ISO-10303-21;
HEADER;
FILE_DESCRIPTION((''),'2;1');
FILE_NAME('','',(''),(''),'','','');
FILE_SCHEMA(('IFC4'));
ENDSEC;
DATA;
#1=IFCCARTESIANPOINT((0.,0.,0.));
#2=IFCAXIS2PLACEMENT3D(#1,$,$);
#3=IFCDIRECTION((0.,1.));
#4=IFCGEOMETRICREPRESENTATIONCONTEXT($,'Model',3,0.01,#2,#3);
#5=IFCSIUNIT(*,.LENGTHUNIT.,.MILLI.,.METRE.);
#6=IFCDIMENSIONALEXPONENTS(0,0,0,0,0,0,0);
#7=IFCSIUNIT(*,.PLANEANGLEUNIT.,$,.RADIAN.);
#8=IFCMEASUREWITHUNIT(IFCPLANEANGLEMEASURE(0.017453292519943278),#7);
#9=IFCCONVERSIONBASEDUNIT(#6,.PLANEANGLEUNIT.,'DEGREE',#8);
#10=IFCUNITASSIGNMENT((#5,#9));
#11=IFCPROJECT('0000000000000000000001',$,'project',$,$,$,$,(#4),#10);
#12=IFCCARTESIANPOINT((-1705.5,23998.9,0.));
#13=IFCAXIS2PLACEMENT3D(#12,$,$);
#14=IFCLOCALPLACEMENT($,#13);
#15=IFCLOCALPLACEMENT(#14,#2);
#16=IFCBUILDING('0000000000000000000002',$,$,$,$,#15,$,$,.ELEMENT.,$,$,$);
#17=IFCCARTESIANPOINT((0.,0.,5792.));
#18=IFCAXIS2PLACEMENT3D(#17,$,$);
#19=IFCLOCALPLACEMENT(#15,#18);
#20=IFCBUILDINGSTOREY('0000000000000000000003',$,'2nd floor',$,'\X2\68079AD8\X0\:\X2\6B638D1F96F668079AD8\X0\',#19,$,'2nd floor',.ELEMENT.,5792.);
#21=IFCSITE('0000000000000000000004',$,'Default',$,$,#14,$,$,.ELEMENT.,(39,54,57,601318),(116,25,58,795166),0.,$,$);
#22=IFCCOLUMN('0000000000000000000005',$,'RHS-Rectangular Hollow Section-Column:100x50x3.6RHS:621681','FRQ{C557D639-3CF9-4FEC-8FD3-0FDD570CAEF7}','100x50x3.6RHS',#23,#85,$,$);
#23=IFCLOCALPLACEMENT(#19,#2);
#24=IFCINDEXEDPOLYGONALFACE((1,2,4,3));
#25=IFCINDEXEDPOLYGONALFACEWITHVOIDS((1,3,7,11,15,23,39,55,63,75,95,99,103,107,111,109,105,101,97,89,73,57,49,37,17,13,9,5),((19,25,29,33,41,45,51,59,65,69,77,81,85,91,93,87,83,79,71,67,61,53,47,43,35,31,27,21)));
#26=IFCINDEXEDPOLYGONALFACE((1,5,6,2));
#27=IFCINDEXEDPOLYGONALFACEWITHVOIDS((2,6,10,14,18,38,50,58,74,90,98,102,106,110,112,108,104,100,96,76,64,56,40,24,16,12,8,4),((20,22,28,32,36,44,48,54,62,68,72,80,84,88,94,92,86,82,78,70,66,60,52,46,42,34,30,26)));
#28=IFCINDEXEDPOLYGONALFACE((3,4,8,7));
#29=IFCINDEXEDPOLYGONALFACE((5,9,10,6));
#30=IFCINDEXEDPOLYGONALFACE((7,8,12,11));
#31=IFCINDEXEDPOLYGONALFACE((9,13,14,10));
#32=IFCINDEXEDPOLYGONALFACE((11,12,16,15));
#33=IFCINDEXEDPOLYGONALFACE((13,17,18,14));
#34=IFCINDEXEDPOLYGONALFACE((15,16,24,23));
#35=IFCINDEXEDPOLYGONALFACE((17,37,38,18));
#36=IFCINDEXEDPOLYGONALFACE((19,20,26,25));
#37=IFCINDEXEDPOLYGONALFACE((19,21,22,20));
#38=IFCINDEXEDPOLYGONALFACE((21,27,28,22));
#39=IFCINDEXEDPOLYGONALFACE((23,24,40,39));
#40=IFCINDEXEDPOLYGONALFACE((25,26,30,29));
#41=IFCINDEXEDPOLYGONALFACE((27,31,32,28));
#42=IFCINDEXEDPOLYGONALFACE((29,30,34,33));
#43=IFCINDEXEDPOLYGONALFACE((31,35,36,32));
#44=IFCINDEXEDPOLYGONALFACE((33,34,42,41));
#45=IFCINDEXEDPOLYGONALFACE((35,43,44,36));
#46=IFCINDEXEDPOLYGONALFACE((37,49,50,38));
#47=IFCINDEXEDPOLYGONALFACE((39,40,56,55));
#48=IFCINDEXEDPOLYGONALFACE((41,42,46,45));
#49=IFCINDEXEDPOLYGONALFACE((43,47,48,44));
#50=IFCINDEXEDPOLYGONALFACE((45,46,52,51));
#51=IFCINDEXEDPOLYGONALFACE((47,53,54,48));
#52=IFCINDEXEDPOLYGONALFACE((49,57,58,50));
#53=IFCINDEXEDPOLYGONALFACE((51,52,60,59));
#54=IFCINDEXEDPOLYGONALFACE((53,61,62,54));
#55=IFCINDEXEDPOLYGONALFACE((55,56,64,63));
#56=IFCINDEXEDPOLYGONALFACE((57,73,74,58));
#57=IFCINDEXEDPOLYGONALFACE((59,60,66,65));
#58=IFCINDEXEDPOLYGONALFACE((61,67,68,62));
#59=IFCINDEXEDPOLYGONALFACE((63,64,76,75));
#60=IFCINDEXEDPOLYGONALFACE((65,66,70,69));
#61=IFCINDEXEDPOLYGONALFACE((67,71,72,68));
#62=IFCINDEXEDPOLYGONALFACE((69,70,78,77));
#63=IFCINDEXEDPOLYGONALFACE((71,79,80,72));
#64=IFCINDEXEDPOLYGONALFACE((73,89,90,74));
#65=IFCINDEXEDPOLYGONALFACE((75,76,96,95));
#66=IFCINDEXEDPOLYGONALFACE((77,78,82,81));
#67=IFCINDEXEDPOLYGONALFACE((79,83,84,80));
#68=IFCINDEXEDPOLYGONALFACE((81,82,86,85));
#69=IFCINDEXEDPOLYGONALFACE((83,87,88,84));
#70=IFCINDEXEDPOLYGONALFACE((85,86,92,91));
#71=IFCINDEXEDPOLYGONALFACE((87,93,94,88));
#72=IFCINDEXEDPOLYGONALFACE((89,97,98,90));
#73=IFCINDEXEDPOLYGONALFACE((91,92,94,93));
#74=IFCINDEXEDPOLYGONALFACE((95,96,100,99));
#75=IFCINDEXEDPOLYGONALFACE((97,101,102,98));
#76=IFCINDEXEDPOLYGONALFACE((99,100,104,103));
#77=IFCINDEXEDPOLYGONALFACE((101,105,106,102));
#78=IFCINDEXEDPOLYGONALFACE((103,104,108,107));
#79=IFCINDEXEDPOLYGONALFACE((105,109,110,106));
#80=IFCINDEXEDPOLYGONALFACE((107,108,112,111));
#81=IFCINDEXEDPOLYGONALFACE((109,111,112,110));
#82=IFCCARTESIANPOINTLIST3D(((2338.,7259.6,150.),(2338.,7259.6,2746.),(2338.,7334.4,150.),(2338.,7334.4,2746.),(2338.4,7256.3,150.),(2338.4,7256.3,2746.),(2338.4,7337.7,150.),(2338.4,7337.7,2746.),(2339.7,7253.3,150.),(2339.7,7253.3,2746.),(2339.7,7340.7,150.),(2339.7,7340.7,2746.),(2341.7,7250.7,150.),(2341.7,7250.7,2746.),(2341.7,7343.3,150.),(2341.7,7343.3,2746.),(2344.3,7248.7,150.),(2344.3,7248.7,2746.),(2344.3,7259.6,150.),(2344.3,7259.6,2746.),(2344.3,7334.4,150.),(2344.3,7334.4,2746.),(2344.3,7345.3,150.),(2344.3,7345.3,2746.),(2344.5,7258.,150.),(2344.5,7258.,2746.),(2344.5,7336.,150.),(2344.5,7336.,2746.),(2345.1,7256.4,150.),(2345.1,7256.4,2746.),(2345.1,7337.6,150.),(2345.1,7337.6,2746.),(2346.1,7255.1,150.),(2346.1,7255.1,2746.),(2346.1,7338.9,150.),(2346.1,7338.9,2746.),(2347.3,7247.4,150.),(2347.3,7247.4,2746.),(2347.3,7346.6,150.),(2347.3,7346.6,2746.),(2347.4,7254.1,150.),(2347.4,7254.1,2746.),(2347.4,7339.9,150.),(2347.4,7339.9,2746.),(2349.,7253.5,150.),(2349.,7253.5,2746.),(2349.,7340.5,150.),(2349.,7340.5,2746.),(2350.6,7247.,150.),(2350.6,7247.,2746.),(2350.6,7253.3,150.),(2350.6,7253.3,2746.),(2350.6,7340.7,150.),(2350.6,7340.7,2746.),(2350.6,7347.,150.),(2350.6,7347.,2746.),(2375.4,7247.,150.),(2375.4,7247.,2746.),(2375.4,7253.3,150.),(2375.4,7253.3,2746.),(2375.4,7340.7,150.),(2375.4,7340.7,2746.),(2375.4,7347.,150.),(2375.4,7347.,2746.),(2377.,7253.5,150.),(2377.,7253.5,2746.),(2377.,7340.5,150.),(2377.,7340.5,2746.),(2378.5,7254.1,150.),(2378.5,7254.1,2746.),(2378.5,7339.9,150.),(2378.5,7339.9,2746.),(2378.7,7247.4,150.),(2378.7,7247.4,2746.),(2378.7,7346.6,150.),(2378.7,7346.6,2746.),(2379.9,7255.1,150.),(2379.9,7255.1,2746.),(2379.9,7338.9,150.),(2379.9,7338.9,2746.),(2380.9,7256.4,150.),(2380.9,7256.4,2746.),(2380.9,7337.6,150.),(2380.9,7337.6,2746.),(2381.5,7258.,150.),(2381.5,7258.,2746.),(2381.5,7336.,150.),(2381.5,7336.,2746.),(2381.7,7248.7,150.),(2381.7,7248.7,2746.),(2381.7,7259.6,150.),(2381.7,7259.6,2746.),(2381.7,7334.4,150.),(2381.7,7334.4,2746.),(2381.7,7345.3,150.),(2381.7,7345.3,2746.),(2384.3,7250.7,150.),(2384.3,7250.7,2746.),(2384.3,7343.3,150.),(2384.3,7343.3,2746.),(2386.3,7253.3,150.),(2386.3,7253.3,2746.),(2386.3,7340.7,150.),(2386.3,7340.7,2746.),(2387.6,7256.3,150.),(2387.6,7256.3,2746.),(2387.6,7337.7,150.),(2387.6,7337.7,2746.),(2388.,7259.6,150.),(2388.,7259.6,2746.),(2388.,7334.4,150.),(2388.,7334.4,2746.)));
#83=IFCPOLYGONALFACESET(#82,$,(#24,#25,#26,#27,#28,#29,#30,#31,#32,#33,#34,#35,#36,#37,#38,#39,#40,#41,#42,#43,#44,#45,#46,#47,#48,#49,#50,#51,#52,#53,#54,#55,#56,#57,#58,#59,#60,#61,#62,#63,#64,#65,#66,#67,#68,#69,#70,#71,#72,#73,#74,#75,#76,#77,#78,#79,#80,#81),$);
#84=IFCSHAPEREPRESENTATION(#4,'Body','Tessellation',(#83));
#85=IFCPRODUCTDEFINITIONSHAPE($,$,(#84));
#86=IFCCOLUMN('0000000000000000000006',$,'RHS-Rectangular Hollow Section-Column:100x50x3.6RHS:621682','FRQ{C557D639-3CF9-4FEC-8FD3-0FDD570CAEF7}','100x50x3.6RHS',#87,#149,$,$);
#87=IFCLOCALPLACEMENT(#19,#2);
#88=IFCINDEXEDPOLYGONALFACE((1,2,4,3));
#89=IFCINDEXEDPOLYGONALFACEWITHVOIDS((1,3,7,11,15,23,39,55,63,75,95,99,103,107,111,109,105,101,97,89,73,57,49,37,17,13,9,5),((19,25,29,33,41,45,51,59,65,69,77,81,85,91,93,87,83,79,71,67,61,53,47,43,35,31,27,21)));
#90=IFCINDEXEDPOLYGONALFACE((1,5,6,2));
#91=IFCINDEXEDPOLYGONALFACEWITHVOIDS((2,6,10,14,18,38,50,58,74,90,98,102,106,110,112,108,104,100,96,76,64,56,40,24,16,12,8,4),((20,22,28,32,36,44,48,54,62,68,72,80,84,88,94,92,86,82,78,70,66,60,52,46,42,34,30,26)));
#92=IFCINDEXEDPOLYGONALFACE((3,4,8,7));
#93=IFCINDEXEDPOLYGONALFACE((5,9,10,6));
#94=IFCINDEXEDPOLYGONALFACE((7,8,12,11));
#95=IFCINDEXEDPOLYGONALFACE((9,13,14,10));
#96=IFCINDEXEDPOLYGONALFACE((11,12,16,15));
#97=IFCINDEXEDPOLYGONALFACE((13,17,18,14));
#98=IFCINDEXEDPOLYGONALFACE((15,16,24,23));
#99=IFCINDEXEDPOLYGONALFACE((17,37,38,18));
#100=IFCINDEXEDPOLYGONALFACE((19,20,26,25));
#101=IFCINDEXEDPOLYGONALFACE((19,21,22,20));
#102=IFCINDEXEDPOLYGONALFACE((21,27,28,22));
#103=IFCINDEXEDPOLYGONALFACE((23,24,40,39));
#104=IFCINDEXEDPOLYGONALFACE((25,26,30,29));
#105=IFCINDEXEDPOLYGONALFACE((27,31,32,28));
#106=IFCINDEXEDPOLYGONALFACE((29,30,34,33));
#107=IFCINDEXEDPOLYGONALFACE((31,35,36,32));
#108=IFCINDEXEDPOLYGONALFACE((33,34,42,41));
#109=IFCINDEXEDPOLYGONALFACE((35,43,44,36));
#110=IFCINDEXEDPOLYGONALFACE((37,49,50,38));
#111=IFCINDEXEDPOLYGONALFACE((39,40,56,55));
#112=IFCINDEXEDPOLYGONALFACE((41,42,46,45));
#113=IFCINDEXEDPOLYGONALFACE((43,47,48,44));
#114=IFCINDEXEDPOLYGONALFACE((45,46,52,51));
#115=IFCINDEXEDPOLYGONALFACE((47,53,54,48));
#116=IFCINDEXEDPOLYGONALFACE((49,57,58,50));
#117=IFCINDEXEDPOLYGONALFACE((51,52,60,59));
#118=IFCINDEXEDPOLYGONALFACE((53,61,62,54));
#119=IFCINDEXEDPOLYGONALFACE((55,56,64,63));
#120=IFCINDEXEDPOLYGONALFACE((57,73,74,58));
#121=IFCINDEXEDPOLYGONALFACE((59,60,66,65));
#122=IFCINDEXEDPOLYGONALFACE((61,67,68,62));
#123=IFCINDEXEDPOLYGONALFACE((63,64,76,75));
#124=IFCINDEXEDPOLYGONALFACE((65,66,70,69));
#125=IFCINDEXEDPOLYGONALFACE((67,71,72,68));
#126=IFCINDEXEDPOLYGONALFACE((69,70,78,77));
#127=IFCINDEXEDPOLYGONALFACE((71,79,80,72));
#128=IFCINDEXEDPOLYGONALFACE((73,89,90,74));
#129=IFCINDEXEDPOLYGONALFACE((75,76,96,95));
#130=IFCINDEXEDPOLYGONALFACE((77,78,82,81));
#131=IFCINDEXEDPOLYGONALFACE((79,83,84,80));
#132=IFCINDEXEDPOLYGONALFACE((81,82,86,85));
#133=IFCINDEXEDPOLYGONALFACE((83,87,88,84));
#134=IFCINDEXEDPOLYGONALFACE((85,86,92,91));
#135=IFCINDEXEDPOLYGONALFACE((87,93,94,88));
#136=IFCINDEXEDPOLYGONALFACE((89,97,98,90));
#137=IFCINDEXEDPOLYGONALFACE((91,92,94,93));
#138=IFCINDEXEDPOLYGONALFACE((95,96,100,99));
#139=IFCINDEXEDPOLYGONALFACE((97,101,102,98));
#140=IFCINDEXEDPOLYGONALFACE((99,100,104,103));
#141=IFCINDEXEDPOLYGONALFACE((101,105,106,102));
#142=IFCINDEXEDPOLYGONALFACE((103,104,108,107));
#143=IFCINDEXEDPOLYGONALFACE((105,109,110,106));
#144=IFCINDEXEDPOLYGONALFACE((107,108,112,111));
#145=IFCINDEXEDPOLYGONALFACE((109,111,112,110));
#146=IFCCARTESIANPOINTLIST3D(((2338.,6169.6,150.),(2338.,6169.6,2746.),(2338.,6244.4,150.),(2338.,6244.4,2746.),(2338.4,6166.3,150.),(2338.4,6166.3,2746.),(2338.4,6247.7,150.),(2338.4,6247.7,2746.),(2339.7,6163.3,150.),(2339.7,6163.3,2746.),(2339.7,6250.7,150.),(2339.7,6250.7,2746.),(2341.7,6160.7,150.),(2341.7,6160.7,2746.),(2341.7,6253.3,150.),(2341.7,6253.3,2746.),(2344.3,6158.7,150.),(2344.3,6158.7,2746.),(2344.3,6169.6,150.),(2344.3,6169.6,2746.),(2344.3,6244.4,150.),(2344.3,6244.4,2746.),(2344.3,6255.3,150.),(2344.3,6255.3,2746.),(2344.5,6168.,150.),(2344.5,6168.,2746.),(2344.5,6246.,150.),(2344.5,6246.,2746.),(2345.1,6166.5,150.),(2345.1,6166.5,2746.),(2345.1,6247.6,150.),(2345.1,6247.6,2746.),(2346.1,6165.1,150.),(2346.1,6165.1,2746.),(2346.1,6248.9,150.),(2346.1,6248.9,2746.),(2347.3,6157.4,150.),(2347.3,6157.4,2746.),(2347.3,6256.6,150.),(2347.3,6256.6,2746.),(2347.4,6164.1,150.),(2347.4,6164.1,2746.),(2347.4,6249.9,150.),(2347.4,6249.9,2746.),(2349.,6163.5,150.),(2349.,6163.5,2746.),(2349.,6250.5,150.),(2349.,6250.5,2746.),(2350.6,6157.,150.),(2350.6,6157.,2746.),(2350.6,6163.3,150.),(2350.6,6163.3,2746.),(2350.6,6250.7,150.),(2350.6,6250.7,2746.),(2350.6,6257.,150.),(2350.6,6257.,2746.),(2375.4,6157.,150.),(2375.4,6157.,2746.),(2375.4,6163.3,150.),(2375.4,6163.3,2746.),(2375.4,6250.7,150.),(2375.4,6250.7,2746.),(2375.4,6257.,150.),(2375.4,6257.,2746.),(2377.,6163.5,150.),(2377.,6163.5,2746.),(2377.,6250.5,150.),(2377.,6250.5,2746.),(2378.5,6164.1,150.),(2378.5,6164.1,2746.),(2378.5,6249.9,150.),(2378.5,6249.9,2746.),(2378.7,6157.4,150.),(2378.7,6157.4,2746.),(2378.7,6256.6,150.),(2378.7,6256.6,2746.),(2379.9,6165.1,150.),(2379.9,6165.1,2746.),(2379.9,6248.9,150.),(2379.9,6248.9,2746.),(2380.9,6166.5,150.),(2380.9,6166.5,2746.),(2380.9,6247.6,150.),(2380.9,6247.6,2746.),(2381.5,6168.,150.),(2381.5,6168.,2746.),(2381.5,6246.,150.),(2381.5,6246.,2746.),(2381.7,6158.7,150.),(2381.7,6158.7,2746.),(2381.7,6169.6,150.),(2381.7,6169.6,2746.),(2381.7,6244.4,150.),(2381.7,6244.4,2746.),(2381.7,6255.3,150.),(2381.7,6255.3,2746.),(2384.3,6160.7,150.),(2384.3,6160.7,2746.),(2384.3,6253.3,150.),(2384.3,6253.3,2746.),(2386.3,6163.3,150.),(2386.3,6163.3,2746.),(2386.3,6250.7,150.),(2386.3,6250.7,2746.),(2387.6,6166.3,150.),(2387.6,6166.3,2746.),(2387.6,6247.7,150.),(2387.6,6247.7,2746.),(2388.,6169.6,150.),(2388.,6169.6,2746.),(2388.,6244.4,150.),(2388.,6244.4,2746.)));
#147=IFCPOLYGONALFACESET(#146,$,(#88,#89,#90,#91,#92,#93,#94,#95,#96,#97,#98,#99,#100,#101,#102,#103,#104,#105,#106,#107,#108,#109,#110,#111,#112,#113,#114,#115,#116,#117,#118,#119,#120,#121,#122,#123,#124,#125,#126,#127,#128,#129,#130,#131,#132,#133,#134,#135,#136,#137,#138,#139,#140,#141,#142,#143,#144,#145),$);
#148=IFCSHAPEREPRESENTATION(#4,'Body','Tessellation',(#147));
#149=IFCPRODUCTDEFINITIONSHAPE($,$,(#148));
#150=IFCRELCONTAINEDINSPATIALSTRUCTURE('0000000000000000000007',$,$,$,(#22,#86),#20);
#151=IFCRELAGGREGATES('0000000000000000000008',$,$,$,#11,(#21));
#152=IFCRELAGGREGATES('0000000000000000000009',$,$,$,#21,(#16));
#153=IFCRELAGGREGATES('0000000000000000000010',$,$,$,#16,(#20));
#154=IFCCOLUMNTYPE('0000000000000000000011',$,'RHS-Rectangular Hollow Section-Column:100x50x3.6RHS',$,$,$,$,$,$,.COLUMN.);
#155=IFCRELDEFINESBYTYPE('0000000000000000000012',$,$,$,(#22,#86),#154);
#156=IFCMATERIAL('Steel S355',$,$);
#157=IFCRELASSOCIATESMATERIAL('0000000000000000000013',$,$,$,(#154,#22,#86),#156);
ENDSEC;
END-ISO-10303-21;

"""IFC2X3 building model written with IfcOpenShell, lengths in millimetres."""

from ifc_helpers import new_model, entity, si_unit, converted_unit, direction, frame, origin, origin_2d, place, context, project, spatial, hollow_rectangle, extrude, clip, halfspace, material, type_object, element, save


model = new_model("IFC2X3")

# Units and contexts
model_context = context("Model", 3, precision=0.01, world=origin(), true_north=direction((0.0, 1.0)))
ifc_project = project(units=[si_unit("LENGTHUNIT", "METRE", prefix="MILLI"), converted_unit("PLANEANGLEUNIT", "DEGREE", entity("IfcPlaneAngleMeasure", 0.017453292519943278), si_unit("PLANEANGLEUNIT", "RADIAN"), dimensions=[0, 0, 0, 0, 0, 0, 0])], contexts=[model_context])

# Site, building, storey
site_placement = place(None, frame((-1705.5, 23998.9, 0.0)))
site = spatial("IfcSite", under=ifc_project, at=site_placement, Name="Default", CompositionType="ELEMENT", RefLatitude=(39, 54, 57, 601318), RefLongitude=(116, 25, 58, 795166), RefElevation=0.0)
building_placement = place(site_placement, origin())
building = spatial("IfcBuilding", under=site, at=building_placement, CompositionType="ELEMENT")
storey_placement = place(building_placement, frame((0.0, 0.0, 5792.0)))
storey = spatial("IfcBuildingStorey", under=building, at=storey_placement, Name="2nd floor", ObjectType="标高:正负零标高", LongName="2nd floor", CompositionType="ELEMENT", Elevation=5792.0)

# Shared definitions
ifc_material_1 = material(Name="Steel S355")

# Columns
column_type_1 = type_object("IfcColumnType", Name="RHS-Rectangular Hollow Section-Column:100x50x3.6RHS", PredefinedType="COLUMN", material=ifc_material_1)
column_1_placement = place(storey_placement, frame((2363.0, 7297.0, 2746.0), z_axis=(0.0, 0.0, 1.0), x_axis=(-1.0, 0.0, 0.0)))
element("IfcColumn", 1, at=column_1_placement, inside=storey, type_object=column_type_1, material=ifc_material_1, Name="RHS-Rectangular Hollow Section-Column:100x50x3.6RHS:621681", Description="FRQ{C557D639-3CF9-4FEC-8FD3-0FDD570CAEF7}", ObjectType="100x50x3.6RHS", context=model_context, shape_type="Clipping", body=[
    clip(extrude(hollow_rectangle(XDim=50.0, YDim=100.0, WallThickness=6.3, InnerFilletRadius=6.3, OuterFilletRadius=12.6, at=origin_2d()), origin(), (0.0, 0.0, -1.0), 2651.9), halfspace(frame((2363.0, 7297.0, -2596.0), z_axis=(0.0, 0.0, 1.0), x_axis=(-1.0, 0.0, 0.0)), True)),
])
column_2_placement = place(storey_placement, frame((2363.0, 6207.0, 2746.0), z_axis=(0.0, 0.0, 1.0), x_axis=(-1.0, 0.0, 0.0)))
element("IfcColumn", 2, at=column_2_placement, inside=storey, type_object=column_type_1, material=ifc_material_1, Name="RHS-Rectangular Hollow Section-Column:100x50x3.6RHS:621682", Description="FRQ{C557D639-3CF9-4FEC-8FD3-0FDD570CAEF7}", ObjectType="100x50x3.6RHS", context=model_context, shape_type="Clipping", body=[
    clip(extrude(hollow_rectangle(XDim=50.0, YDim=100.0, WallThickness=6.3, InnerFilletRadius=6.3, OuterFilletRadius=12.6, at=origin_2d()), origin(), (0.0, 0.0, -1.0), 2651.9), halfspace(frame((2363.0, 6207.0, -2596.0), z_axis=(0.0, 0.0, 1.0), x_axis=(-1.0, 0.0, 0.0)), True)),
])

save(model, "model.ifc")
